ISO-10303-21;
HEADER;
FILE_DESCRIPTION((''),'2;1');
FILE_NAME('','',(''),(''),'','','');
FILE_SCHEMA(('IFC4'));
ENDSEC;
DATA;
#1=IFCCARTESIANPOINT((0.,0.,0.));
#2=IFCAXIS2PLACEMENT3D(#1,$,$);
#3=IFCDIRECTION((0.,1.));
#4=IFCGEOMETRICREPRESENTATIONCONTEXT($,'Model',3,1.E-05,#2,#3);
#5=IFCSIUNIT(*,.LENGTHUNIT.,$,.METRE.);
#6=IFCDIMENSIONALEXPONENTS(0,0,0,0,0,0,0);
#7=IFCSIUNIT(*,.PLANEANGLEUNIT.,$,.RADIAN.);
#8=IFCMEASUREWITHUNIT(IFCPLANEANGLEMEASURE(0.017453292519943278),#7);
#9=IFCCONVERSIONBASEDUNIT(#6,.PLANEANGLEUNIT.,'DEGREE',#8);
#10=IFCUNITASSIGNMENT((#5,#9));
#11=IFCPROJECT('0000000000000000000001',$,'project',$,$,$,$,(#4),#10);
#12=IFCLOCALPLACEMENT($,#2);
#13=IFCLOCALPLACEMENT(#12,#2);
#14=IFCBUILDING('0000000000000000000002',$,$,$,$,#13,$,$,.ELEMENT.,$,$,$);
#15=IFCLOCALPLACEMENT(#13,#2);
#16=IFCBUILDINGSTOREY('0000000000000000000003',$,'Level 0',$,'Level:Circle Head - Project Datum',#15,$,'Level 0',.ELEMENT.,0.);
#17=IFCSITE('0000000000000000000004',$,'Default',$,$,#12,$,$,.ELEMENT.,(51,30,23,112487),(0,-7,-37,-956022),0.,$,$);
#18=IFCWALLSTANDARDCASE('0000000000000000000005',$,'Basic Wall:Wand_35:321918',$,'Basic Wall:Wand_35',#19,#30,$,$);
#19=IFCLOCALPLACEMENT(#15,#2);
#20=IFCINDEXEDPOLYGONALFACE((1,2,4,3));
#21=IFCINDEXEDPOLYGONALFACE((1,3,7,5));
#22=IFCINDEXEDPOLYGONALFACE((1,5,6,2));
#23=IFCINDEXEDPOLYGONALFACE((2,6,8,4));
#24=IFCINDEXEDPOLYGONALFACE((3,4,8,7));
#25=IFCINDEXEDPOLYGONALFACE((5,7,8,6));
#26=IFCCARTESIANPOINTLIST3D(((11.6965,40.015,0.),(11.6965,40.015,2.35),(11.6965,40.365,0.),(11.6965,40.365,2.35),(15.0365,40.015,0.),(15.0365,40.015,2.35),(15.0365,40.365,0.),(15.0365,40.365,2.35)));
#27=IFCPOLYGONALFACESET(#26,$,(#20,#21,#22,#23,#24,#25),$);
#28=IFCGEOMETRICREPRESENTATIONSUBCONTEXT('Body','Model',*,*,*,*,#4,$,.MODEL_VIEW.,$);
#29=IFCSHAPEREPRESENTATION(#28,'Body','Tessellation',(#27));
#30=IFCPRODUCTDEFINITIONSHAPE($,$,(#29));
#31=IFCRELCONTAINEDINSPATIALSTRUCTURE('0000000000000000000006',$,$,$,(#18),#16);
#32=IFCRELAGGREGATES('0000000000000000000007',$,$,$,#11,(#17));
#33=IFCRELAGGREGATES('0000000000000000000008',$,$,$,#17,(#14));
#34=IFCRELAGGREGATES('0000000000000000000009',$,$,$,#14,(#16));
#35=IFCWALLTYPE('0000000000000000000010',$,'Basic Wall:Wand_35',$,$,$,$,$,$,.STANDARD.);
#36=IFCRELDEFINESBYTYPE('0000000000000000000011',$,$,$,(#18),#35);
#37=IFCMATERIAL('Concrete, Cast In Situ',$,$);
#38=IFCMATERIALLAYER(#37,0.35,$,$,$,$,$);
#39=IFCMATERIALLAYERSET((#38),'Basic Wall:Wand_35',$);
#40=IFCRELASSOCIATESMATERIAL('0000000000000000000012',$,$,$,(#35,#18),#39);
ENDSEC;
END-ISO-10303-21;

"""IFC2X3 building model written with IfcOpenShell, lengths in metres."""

from ifc_helpers import new_model, entity, si_unit, converted_unit, direction, frame, frame_2d, origin, place, context, subcontext, project, spatial, rectangle, extrude, material, layer, layer_set, layer_usage, type_object, element, save


model = new_model("IFC2X3")

# Units and contexts
model_context = context("Model", 3, precision=1e-05, world=origin(), true_north=direction((0.0, 1.0)))
body_context = subcontext(model_context, "Body", "Model", "MODEL_VIEW")
ifc_project = project(units=[si_unit("LENGTHUNIT", "METRE"), converted_unit("PLANEANGLEUNIT", "DEGREE", entity("IfcPlaneAngleMeasure", 0.017453292519943278), si_unit("PLANEANGLEUNIT", "RADIAN"), dimensions=[0, 0, 0, 0, 0, 0, 0])], contexts=[model_context])

# Site, building, storey
site_placement = place(None, origin())
site = spatial("IfcSite", under=ifc_project, at=site_placement, Name="Default", CompositionType="ELEMENT", RefLatitude=(51, 30, 23, 112487), RefLongitude=(0, -7, -37, -956022), RefElevation=0.0)
building_placement = place(site_placement, origin())
building = spatial("IfcBuilding", under=site, at=building_placement, CompositionType="ELEMENT")
storey_placement = place(building_placement, origin())
storey = spatial("IfcBuildingStorey", under=building, at=storey_placement, Name="Level 0", ObjectType="Level:Circle Head - Project Datum", LongName="Level 0", CompositionType="ELEMENT", Elevation=0.0)

# Shared definitions
ifc_material_1 = material(Name="Concrete, Cast In Situ")

# Wall
ifc_layer_1 = layer(ifc_material_1, 0.35)
ifc_layer_set_1 = layer_set([ifc_layer_1], Name="Basic Wall:Wand_35")
ifc_layer_usage_1 = layer_usage(ifc_layer_set_1, "AXIS2", "NEGATIVE", 0.175)
wall_type_1 = type_object("IfcWallType", Name="Basic Wall:Wand_35", PredefinedType="STANDARD", material=ifc_layer_set_1)
wall_1_placement = place(storey_placement, frame((15.0365, 40.19, 0.0), z_axis=(0.0, 0.0, 1.0), x_axis=(-1.0, 0.0, 0.0)))
element("IfcWallStandardCase", 1, at=wall_1_placement, inside=storey, type_object=wall_type_1, material=ifc_layer_usage_1, Name="Basic Wall:Wand_35:321918", ObjectType="Basic Wall:Wand_35", context=body_context, shape_type="SweptSolid", body=[
    extrude(rectangle(XDim=3.34, YDim=0.35, at=frame_2d((1.67, 0.0), x_axis=(-1.0, 0.0))), origin(), (0.0, 0.0, 1.0), 2.35),
])

save(model, "model.ifc")
